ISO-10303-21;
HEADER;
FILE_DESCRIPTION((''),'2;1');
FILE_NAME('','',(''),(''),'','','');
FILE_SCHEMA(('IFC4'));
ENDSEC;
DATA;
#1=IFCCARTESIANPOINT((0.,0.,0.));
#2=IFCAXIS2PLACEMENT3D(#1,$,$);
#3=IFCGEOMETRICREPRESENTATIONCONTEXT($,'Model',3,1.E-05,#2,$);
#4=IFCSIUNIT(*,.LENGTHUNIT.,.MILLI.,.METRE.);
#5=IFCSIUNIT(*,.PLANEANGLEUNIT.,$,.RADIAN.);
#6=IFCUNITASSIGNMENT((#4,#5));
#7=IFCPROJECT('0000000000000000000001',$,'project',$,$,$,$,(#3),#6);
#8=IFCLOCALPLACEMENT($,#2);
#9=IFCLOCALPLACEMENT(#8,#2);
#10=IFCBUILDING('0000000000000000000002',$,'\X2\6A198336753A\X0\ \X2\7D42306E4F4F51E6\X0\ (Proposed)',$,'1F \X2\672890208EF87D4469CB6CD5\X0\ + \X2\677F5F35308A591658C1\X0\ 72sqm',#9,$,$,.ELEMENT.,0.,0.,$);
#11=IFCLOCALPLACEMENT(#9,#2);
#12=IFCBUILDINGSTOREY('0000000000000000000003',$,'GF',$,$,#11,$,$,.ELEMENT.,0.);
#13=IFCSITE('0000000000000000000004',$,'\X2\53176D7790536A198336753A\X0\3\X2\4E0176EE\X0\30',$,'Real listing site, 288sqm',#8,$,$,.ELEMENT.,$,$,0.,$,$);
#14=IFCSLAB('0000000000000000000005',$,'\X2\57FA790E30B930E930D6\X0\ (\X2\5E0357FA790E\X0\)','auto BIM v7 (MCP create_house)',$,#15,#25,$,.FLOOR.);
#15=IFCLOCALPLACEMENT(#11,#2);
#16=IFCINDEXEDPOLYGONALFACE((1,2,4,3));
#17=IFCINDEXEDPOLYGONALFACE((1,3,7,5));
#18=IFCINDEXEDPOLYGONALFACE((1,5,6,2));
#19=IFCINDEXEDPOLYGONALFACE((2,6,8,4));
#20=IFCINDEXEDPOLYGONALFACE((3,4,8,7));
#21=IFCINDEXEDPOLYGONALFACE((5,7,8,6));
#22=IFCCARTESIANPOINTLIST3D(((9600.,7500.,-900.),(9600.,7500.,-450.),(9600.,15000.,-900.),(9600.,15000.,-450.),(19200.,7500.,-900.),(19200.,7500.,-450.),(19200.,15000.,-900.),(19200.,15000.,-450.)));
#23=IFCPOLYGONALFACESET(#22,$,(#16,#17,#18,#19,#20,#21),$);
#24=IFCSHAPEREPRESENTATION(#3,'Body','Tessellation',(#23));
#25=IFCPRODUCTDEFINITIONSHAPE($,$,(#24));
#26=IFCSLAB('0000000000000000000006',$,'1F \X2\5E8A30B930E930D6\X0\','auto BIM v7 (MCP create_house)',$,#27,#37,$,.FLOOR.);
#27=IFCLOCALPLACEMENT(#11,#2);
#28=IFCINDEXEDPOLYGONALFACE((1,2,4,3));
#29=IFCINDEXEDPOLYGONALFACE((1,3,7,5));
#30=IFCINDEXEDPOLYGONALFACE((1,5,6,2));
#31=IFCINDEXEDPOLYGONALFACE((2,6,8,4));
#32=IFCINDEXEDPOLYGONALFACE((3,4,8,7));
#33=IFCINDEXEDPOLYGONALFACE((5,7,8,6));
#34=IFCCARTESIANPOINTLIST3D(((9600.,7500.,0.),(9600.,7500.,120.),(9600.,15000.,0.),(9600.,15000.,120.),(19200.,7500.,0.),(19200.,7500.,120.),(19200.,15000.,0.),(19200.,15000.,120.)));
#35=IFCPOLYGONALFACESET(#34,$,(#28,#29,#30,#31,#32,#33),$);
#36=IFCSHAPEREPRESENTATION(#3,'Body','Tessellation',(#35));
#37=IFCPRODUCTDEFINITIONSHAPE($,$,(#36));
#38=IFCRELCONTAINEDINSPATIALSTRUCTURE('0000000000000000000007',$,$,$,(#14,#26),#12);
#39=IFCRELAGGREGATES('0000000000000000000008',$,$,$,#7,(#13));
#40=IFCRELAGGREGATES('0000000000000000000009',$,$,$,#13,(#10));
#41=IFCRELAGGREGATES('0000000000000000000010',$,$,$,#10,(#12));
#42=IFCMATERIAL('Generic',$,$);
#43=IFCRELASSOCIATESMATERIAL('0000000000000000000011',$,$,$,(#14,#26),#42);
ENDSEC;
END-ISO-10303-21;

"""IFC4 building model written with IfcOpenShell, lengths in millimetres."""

from ifc_helpers import new_model, si_unit, frame, frame_2d, origin, place, context, project, spatial, rectangle, extrude, material, element, save


model = new_model("IFC4")

# Units and contexts
model_context = context("Model", 3, precision=1e-05, world=origin())
ifc_project = project(units=[si_unit("LENGTHUNIT", "METRE", prefix="MILLI"), si_unit("PLANEANGLEUNIT", "RADIAN")], contexts=[model_context])

# Site, building, storey
site_placement = place(None, origin())
site = spatial("IfcSite", under=ifc_project, at=site_placement, Name="北海道標茶町3丁目30", ObjectType="Real listing site, 288sqm", CompositionType="ELEMENT", RefElevation=0.0)
building_placement = place(site_placement, origin())
building = spatial("IfcBuilding", under=site, at=building_placement, Name="標茶町 終の住処 (Proposed)", ObjectType="1F 木造軸組構法 + 板張り外壁 72sqm", CompositionType="ELEMENT", ElevationOfRefHeight=0.0, ElevationOfTerrain=0.0)
storey_placement = place(building_placement, origin())
storey = spatial("IfcBuildingStorey", under=building, at=storey_placement, Name="GF", CompositionType="ELEMENT", Elevation=0.0)

# Slabs
ifc_material = material(Name="Generic")
slab_1_placement = place(storey_placement, frame((4800.0, 3750.0, -450.0)))
element("IfcSlab", 1, at=slab_1_placement, inside=storey, material=ifc_material, Name="基礎スラブ (布基礎)", Description="auto BIM v7 (MCP create_house)", PredefinedType="FLOOR", context=model_context, shape_type="SweptSolid", body=[
    extrude(rectangle(XDim=9600.0, YDim=7500.0, at=frame_2d((4800.0, 3750.0))), frame((4800.0, 3750.0, -450.0)), (0.0, 0.0, 1.0), 450.0),
])
slab_2_placement = place(storey_placement, frame((4800.0, 3750.0, 0.0)))
element("IfcSlab", 2, at=slab_2_placement, inside=storey, material=ifc_material, Name="1F 床スラブ", Description="auto BIM v7 (MCP create_house)", PredefinedType="FLOOR", context=model_context, shape_type="SweptSolid", body=[
    extrude(rectangle(XDim=9600.0, YDim=7500.0, at=frame_2d((4800.0, 3750.0))), frame((4800.0, 3750.0, 0.0)), (0.0, 0.0, 1.0), 120.0),
])

save(model, "model.ifc")
